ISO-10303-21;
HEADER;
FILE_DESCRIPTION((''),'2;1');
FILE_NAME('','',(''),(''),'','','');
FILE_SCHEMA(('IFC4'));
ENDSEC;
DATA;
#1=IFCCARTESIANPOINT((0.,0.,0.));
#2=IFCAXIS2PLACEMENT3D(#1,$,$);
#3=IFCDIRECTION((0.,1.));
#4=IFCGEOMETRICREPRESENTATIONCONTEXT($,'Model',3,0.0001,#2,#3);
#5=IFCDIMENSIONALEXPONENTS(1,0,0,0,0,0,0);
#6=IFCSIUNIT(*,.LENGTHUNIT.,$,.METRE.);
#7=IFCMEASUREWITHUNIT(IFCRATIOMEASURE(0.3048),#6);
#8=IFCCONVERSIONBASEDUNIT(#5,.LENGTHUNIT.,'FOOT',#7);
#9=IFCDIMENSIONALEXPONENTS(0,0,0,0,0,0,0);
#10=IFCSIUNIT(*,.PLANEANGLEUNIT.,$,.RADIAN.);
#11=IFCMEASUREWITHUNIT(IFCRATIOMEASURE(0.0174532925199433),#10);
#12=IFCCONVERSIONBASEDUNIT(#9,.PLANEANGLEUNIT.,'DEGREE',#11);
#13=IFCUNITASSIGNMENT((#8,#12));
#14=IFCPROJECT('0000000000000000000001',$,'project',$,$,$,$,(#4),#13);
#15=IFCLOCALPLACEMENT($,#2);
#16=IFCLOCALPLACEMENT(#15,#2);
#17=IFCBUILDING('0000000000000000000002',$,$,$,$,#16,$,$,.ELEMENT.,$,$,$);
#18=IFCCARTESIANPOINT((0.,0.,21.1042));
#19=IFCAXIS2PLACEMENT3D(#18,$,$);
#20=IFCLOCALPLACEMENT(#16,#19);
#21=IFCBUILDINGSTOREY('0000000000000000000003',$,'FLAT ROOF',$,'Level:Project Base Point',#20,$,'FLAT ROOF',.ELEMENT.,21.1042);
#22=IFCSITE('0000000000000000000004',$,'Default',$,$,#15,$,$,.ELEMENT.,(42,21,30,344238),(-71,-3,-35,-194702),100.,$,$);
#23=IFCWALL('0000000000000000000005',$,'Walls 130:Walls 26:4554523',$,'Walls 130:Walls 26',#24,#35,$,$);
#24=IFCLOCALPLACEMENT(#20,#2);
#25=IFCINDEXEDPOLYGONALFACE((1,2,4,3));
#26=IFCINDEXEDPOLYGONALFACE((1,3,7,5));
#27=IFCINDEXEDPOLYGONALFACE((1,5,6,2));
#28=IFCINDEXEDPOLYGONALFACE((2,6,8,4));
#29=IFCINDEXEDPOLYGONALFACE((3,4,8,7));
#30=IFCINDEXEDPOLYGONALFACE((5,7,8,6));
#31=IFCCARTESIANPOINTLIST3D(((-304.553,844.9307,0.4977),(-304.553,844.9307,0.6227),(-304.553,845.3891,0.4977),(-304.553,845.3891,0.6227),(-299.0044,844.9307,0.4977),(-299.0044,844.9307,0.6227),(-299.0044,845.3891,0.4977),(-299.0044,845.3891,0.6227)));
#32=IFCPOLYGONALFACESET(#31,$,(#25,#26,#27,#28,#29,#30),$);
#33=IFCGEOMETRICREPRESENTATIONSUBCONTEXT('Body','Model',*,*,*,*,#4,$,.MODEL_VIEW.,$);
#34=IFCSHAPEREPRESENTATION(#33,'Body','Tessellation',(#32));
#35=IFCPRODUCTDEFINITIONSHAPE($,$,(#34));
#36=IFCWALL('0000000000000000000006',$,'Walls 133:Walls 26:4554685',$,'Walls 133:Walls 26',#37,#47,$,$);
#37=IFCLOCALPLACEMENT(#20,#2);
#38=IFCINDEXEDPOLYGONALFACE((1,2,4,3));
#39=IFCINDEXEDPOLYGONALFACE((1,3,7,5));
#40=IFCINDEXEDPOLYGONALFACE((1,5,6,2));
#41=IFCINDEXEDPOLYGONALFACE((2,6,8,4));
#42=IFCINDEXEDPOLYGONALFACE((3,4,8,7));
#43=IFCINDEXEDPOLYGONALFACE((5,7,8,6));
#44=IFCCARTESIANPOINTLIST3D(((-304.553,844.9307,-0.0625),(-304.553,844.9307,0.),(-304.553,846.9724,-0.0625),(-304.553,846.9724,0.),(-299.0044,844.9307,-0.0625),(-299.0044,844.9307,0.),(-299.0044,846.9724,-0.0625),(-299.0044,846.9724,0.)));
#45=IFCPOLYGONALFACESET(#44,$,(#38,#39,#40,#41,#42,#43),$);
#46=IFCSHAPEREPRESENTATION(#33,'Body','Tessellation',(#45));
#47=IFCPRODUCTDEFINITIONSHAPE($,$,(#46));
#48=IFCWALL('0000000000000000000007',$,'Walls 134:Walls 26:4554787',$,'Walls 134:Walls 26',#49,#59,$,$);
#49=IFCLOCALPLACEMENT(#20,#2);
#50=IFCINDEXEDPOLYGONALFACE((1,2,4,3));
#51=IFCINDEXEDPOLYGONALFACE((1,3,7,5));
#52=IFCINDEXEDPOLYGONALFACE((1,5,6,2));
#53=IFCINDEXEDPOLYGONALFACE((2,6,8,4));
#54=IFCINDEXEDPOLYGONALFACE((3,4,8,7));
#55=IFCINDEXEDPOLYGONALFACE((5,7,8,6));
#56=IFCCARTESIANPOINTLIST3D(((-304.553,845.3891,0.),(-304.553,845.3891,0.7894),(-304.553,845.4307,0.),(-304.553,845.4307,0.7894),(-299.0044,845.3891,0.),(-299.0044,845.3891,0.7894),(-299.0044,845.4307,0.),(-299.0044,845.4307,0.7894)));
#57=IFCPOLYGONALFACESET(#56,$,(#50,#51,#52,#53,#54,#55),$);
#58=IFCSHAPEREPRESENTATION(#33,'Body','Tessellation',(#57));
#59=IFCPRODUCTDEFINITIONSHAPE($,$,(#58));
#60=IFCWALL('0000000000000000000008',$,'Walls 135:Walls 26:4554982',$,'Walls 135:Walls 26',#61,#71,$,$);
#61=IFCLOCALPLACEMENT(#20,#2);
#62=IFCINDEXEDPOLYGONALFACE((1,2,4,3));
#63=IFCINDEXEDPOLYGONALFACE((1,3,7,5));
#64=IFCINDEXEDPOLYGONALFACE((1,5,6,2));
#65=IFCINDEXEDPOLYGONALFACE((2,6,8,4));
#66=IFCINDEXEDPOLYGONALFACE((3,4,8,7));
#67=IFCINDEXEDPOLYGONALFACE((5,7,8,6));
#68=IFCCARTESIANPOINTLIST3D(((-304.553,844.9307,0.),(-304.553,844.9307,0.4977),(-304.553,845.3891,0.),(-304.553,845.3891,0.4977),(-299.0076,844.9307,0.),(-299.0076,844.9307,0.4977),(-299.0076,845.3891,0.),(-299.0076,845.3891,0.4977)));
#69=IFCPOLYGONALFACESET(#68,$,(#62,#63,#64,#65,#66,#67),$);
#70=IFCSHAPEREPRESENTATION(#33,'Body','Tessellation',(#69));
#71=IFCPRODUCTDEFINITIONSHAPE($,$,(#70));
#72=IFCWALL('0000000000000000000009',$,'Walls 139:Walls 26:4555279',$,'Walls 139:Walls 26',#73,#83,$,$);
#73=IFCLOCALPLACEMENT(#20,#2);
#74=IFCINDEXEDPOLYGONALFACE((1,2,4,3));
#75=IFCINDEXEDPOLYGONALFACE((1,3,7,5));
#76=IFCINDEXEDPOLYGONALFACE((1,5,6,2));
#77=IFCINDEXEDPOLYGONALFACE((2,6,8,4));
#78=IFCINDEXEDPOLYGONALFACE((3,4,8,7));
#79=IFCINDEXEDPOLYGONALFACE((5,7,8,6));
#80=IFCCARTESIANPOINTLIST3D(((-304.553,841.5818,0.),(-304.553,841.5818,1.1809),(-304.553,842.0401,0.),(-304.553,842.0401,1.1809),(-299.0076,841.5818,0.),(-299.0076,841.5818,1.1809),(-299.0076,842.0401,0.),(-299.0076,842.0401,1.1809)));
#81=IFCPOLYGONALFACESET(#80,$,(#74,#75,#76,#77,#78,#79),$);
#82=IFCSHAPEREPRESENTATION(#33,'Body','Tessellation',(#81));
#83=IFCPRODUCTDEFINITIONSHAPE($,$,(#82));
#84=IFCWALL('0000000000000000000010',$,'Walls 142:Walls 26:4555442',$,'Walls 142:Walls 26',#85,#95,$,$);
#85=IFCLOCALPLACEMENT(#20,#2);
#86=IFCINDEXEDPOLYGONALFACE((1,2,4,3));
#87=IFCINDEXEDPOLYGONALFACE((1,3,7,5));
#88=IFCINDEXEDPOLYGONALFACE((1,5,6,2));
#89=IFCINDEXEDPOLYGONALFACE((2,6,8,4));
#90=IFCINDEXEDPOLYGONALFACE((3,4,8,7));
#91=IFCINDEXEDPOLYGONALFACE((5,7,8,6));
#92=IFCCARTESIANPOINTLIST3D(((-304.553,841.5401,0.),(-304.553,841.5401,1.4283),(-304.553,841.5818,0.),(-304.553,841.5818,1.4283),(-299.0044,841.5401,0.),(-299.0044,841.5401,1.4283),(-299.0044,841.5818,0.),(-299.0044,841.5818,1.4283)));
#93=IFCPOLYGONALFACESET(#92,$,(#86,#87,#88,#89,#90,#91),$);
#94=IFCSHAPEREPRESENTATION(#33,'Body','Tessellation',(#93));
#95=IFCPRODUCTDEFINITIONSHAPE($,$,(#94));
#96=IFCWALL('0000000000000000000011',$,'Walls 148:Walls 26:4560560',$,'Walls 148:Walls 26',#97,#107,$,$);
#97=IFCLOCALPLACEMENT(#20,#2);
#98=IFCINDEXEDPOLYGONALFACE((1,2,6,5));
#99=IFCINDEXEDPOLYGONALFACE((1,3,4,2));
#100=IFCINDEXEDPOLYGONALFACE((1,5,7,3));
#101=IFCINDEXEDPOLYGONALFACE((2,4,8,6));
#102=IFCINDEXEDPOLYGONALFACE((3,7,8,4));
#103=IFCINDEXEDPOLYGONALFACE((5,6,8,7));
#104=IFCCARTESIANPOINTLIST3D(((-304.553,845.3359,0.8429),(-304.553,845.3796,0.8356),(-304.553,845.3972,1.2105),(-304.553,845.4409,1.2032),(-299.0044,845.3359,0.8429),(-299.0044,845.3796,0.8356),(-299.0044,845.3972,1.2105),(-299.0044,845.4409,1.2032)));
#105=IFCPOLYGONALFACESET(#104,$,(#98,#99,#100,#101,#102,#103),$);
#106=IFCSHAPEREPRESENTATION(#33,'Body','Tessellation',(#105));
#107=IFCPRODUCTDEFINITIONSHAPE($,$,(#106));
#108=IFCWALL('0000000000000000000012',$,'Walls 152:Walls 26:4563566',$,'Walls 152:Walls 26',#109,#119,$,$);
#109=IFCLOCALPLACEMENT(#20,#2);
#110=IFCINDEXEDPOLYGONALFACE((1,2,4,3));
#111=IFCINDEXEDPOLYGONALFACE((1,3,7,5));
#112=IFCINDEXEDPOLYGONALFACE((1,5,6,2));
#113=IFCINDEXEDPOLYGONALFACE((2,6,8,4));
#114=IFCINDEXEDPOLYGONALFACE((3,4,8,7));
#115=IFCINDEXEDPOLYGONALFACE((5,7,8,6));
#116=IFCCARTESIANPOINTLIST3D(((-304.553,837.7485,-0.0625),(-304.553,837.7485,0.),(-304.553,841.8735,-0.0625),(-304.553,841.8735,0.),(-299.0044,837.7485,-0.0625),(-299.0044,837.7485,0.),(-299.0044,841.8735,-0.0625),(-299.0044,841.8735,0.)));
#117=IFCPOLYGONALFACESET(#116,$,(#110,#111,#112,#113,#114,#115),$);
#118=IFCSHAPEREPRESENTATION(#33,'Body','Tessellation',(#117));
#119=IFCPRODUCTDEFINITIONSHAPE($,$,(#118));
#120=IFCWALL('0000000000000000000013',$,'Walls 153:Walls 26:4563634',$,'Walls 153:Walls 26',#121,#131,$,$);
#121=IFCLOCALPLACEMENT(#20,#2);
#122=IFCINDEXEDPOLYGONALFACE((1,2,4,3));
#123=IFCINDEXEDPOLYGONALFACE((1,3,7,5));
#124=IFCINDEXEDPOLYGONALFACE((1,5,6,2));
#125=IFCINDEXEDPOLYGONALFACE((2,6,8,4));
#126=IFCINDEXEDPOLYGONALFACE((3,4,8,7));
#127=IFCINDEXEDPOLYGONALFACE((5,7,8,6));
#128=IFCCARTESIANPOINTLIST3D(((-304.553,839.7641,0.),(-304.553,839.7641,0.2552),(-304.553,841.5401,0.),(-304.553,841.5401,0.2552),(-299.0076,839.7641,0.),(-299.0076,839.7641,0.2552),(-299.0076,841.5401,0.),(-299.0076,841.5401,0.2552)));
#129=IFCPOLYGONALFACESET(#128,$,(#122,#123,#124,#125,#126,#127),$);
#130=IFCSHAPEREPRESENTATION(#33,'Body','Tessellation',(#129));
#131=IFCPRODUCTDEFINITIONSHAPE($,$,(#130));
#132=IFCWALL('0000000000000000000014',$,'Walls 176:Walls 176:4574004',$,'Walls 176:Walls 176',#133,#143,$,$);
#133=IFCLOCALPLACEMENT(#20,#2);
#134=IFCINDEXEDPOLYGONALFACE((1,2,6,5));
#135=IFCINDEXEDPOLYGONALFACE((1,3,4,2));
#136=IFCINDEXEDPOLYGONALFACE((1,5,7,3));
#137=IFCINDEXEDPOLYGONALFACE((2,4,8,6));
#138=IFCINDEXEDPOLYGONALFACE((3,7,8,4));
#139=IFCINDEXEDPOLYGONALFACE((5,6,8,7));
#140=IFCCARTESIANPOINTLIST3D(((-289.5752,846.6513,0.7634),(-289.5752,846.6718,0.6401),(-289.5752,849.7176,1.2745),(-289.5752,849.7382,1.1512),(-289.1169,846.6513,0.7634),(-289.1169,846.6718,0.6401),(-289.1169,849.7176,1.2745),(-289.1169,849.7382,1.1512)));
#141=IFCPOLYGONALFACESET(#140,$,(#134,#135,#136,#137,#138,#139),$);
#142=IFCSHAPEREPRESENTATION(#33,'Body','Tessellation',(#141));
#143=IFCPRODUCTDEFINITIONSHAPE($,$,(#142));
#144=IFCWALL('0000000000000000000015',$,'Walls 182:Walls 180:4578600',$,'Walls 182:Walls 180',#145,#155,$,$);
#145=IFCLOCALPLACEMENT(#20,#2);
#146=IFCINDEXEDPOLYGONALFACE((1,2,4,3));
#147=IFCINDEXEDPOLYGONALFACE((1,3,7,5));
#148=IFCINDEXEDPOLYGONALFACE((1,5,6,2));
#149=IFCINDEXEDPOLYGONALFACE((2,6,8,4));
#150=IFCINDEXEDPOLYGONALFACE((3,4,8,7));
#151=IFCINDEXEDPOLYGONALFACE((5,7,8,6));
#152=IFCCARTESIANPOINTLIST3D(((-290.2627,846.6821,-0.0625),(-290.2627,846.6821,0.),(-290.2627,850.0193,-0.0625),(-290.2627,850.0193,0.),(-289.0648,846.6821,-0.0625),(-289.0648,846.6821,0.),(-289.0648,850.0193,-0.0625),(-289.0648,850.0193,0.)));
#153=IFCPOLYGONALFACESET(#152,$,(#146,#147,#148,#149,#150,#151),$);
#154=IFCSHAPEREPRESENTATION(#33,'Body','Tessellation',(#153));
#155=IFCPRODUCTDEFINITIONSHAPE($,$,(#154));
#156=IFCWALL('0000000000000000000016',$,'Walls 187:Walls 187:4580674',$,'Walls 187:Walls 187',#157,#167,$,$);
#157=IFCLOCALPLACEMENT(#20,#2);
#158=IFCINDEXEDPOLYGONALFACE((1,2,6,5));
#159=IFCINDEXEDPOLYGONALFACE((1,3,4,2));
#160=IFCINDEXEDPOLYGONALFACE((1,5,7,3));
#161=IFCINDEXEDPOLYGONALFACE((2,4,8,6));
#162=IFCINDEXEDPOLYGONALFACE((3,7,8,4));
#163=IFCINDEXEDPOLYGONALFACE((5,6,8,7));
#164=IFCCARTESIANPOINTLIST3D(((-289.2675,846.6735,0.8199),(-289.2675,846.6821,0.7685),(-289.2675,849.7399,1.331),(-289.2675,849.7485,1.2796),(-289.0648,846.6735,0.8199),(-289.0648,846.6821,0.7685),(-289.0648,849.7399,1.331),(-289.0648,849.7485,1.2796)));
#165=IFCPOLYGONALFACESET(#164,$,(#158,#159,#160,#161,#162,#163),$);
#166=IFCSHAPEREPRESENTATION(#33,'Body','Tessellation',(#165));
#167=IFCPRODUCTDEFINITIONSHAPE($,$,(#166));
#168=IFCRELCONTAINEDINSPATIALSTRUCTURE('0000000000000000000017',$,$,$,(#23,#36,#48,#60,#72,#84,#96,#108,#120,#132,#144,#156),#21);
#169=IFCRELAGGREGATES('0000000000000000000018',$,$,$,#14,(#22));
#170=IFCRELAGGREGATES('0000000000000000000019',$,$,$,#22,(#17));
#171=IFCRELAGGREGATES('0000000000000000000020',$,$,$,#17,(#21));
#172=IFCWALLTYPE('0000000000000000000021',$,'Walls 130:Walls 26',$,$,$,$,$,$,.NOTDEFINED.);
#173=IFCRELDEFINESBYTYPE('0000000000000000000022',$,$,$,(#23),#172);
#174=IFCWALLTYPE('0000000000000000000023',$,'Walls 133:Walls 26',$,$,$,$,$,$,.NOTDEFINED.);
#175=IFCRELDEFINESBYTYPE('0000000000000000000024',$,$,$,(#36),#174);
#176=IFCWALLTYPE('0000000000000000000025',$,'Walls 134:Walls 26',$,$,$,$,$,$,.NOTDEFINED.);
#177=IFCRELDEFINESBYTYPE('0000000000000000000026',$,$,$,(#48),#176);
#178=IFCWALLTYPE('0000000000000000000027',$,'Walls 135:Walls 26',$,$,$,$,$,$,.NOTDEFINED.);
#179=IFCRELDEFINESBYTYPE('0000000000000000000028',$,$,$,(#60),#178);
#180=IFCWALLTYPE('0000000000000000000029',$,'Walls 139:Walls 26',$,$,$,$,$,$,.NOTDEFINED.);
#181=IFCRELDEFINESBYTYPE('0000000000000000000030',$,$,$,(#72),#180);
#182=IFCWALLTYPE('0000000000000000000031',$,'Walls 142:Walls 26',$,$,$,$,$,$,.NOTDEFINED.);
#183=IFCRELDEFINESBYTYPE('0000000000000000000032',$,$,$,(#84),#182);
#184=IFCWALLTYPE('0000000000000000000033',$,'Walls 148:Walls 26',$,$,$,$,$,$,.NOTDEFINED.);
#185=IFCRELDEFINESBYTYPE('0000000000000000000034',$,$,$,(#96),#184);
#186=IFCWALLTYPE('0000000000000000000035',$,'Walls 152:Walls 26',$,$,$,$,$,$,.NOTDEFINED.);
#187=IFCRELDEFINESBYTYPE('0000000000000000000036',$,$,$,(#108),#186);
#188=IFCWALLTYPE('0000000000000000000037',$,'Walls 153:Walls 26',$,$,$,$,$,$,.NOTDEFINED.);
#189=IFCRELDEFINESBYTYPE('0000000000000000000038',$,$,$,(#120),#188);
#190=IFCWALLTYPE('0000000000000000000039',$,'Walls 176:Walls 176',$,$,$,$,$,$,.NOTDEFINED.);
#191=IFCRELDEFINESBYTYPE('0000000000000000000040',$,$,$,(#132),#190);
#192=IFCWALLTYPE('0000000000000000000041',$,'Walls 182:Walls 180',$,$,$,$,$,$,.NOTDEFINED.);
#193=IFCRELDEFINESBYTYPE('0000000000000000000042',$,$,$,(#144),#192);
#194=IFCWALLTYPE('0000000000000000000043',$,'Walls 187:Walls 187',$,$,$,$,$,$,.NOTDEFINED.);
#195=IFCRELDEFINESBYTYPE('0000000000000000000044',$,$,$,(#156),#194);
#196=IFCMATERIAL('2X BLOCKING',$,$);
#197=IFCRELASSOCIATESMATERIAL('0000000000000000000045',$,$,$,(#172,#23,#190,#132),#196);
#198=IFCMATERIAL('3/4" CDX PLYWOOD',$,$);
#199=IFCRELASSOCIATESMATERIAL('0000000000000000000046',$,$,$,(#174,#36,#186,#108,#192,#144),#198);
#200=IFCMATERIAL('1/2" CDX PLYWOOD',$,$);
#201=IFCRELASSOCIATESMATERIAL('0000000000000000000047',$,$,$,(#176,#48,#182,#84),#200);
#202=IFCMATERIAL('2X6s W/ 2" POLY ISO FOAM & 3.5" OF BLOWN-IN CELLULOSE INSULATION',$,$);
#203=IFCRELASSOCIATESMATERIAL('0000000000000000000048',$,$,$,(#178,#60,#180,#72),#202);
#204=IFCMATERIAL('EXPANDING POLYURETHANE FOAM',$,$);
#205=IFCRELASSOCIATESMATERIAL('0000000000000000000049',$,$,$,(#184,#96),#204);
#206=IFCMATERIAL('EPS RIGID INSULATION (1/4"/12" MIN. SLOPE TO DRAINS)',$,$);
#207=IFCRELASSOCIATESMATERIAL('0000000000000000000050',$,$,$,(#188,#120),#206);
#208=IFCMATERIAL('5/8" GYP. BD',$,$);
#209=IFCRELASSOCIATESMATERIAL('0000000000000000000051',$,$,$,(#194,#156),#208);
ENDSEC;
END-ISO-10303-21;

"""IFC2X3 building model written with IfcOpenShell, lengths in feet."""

from ifc_helpers import new_model, entity, si_unit, converted_unit, direction, frame, frame_2d, origin, origin_2d_with_axis, place, context, subcontext, project, spatial, rectangle, extrude, material, type_object, element, save


model = new_model("IFC2X3")

# Units and contexts
model_context = context("Model", 3, precision=0.0001, world=origin(), true_north=direction((0.0, 1.0)))
body_context = subcontext(model_context, "Body", "Model", "MODEL_VIEW")
ifc_project = project(units=[converted_unit("LENGTHUNIT", "FOOT", entity("IfcRatioMeasure", 0.3048), si_unit("LENGTHUNIT", "METRE"), dimensions=[1, 0, 0, 0, 0, 0, 0]), converted_unit("PLANEANGLEUNIT", "DEGREE", entity("IfcRatioMeasure", 0.0174532925199433), si_unit("PLANEANGLEUNIT", "RADIAN"), dimensions=[0, 0, 0, 0, 0, 0, 0])], contexts=[model_context])

# Site, building, storey
site_placement = place(None, origin())
site = spatial("IfcSite", under=ifc_project, at=site_placement, Name="Default", CompositionType="ELEMENT", RefLatitude=(42, 21, 30, 344238), RefLongitude=(-71, -3, -35, -194702), RefElevation=100.0)
building_placement = place(site_placement, origin())
building = spatial("IfcBuilding", under=site, at=building_placement, CompositionType="ELEMENT")
storey_placement = place(building_placement, frame((0.0, 0.0, 21.1042)))
storey = spatial("IfcBuildingStorey", under=building, at=storey_placement, Name="FLAT ROOF", ObjectType="Level:Project Base Point", LongName="FLAT ROOF", CompositionType="ELEMENT", Elevation=21.1042)

# Walls
ifc_material_1 = material(Name="1/2\" CDX PLYWOOD")
ifc_material_2 = material(Name="3/4\" CDX PLYWOOD")
ifc_material_3 = material(Name="EPS RIGID INSULATION (1/4\"/12\" MIN. SLOPE TO DRAINS)")
ifc_material_4 = material(Name="2X BLOCKING")
wall_type_1 = type_object("IfcWallType", Name="Walls 130:Walls 26", PredefinedType="NOTDEFINED", material=ifc_material_4)
wall_1_placement = place(storey_placement, frame((-304.553, 844.9307, 0.4977)))
element("IfcWall", 1, at=wall_1_placement, inside=storey, type_object=wall_type_1, material=ifc_material_4, Name="Walls 130:Walls 26:4554523", ObjectType="Walls 130:Walls 26", context=body_context, shape_type="SweptSolid", body=[
    extrude(rectangle(XDim=5.5486, YDim=0.4583, at=origin_2d_with_axis()), frame((2.7743, 0.2292, 0.0), z_axis=(0.0, 0.0, 1.0), x_axis=(-1.0, 0.0, 0.0)), (0.0, 0.0, 1.0), 0.125),
])
wall_type_2 = type_object("IfcWallType", Name="Walls 133:Walls 26", PredefinedType="NOTDEFINED", material=ifc_material_2)
wall_2_placement = place(storey_placement, frame((-304.553, 844.9307, -0.0625)))
element("IfcWall", 2, at=wall_2_placement, inside=storey, type_object=wall_type_2, material=ifc_material_2, Name="Walls 133:Walls 26:4554685", ObjectType="Walls 133:Walls 26", context=body_context, shape_type="SweptSolid", body=[
    extrude(rectangle(XDim=5.5486, YDim=2.0417, at=frame_2d((0.0, 0.0), x_axis=(1.0, 0.0))), frame((2.7743, 1.0208, 0.0), z_axis=(0.0, 0.0, 1.0), x_axis=(-1.0, 0.0, 0.0)), (0.0, 0.0, 1.0), 0.0625),
])
wall_type_3 = type_object("IfcWallType", Name="Walls 134:Walls 26", PredefinedType="NOTDEFINED", material=ifc_material_1)
wall_3_placement = place(storey_placement, frame((-304.553, 845.3891, 0.0)))
element("IfcWall", 3, at=wall_3_placement, inside=storey, type_object=wall_type_3, material=ifc_material_1, Name="Walls 134:Walls 26:4554787", ObjectType="Walls 134:Walls 26", context=body_context, shape_type="SweptSolid", body=[
    extrude(rectangle(XDim=5.5486, YDim=0.0417, at=frame_2d((0.0, 0.0), x_axis=(1.0, 0.0))), frame((2.7743, 0.0208, 0.0), z_axis=(0.0, 0.0, 1.0), x_axis=(-1.0, 0.0, 0.0)), (0.0, 0.0, 1.0), 0.7894),
])
ifc_material_5 = material(Name="2X6s W/ 2\" POLY ISO FOAM & 3.5\" OF BLOWN-IN CELLULOSE INSULATION")
wall_type_4 = type_object("IfcWallType", Name="Walls 135:Walls 26", PredefinedType="NOTDEFINED", material=ifc_material_5)
wall_4_placement = place(storey_placement, frame((-304.553, 844.9307, 0.0)))
element("IfcWall", 4, at=wall_4_placement, inside=storey, type_object=wall_type_4, material=ifc_material_5, Name="Walls 135:Walls 26:4554982", ObjectType="Walls 135:Walls 26", context=body_context, shape_type="SweptSolid", body=[
    extrude(rectangle(XDim=5.5454, YDim=0.4583, at=origin_2d_with_axis()), frame((2.7727, 0.2292, 0.0), z_axis=(0.0, 0.0, 1.0), x_axis=(-1.0, 0.0, 0.0)), (0.0, 0.0, 1.0), 0.4977),
])
wall_type_5 = type_object("IfcWallType", Name="Walls 139:Walls 26", PredefinedType="NOTDEFINED", material=ifc_material_5)
wall_5_placement = place(storey_placement, frame((-304.553, 841.5818, 0.0)))
element("IfcWall", 5, at=wall_5_placement, inside=storey, type_object=wall_type_5, material=ifc_material_5, Name="Walls 139:Walls 26:4555279", ObjectType="Walls 139:Walls 26", context=body_context, shape_type="SweptSolid", body=[
    extrude(rectangle(XDim=5.5454, YDim=0.4583, at=origin_2d_with_axis()), frame((2.7727, 0.2292, 0.0), z_axis=(0.0, 0.0, 1.0), x_axis=(-1.0, 0.0, 0.0)), (0.0, 0.0, 1.0), 1.1809),
])
wall_type_6 = type_object("IfcWallType", Name="Walls 142:Walls 26", PredefinedType="NOTDEFINED", material=ifc_material_1)
wall_6_placement = place(storey_placement, frame((-304.553, 841.5401, 0.0)))
element("IfcWall", 6, at=wall_6_placement, inside=storey, type_object=wall_type_6, material=ifc_material_1, Name="Walls 142:Walls 26:4555442", ObjectType="Walls 142:Walls 26", context=body_context, shape_type="SweptSolid", body=[
    extrude(rectangle(XDim=5.5486, YDim=0.0417, at=frame_2d((0.0, 0.0), x_axis=(1.0, 0.0))), frame((2.7743, 0.0208, 0.0), z_axis=(0.0, 0.0, 1.0), x_axis=(-1.0, 0.0, 0.0)), (0.0, 0.0, 1.0), 1.4283),
])
ifc_material_6 = material(Name="EXPANDING POLYURETHANE FOAM")
wall_type_7 = type_object("IfcWallType", Name="Walls 148:Walls 26", PredefinedType="NOTDEFINED", material=ifc_material_6)
wall_7_placement = place(storey_placement, frame((-304.553, 845.3359, 0.8356)))
element("IfcWall", 7, at=wall_7_placement, inside=storey, type_object=wall_type_7, material=ifc_material_6, Name="Walls 148:Walls 26:4560560", ObjectType="Walls 148:Walls 26", context=body_context, shape_type="SweptSolid", body=[
    extrude(rectangle(XDim=0.0443, YDim=5.5486, at=frame_2d((0.0, 0.0), x_axis=(0.0, 1.0))), frame((2.7743, 0.0219, 0.0036), z_axis=(0.0, 0.164399, 0.986394), x_axis=(-1.0, 0.0, 0.0)), (0.0, 0.0, 1.0), 0.3726),
])
wall_type_8 = type_object("IfcWallType", Name="Walls 152:Walls 26", PredefinedType="NOTDEFINED", material=ifc_material_2)
wall_8_placement = place(storey_placement, frame((-304.553, 837.7485, -0.0625)))
element("IfcWall", 8, at=wall_8_placement, inside=storey, type_object=wall_type_8, material=ifc_material_2, Name="Walls 152:Walls 26:4563566", ObjectType="Walls 152:Walls 26", context=body_context, shape_type="SweptSolid", body=[
    extrude(rectangle(XDim=5.5486, YDim=4.125, at=origin_2d_with_axis()), frame((2.7743, 2.0625, 0.0), z_axis=(0.0, 0.0, 1.0), x_axis=(-1.0, 0.0, 0.0)), (0.0, 0.0, 1.0), 0.0625),
])
wall_type_9 = type_object("IfcWallType", Name="Walls 153:Walls 26", PredefinedType="NOTDEFINED", material=ifc_material_3)
wall_9_placement = place(storey_placement, frame((-304.553, 839.7641, 0.0)))
element("IfcWall", 9, at=wall_9_placement, inside=storey, type_object=wall_type_9, material=ifc_material_3, Name="Walls 153:Walls 26:4563634", ObjectType="Walls 153:Walls 26", context=body_context, shape_type="SweptSolid", body=[
    extrude(rectangle(XDim=5.5454, YDim=1.776, at=frame_2d((0.0, 0.0), x_axis=(1.0, 0.0))), frame((2.7727, 0.888, 0.0), z_axis=(0.0, 0.0, 1.0), x_axis=(-1.0, 0.0, 0.0)), (0.0, 0.0, 1.0), 0.2552),
])
wall_type_10 = type_object("IfcWallType", Name="Walls 176:Walls 176", PredefinedType="NOTDEFINED", material=ifc_material_4)
wall_10_placement = place(storey_placement, frame((-289.5752, 846.6513, 0.6401), z_axis=(0.0, 0.0, 1.0), x_axis=(0.0, 1.0, 0.0)))
element("IfcWall", 10, at=wall_10_placement, inside=storey, type_object=wall_type_10, material=ifc_material_4, Name="Walls 176:Walls 176:4574004", ObjectType="Walls 176:Walls 176", context=body_context, shape_type="SweptSolid", body=[
    extrude(rectangle(XDim=3.1086, YDim=0.4583, at=frame_2d((0.0, 0.0), x_axis=(1.0, 0.0))), frame((1.5537, -0.2292, 0.2555), z_axis=(-0.164399, 0.0, 0.986394), x_axis=(-0.986394, 0.0, -0.164399)), (0.0, 0.0, 1.0), 0.125),
])
wall_type_11 = type_object("IfcWallType", Name="Walls 182:Walls 180", PredefinedType="NOTDEFINED", material=ifc_material_2)
wall_11_placement = place(storey_placement, frame((-290.2627, 846.6821, -0.0625), z_axis=(0.0, 0.0, 1.0), x_axis=(0.0, 1.0, 0.0)))
element("IfcWall", 11, at=wall_11_placement, inside=storey, type_object=wall_type_11, material=ifc_material_2, Name="Walls 182:Walls 180:4578600", ObjectType="Walls 182:Walls 180", context=body_context, shape_type="SweptSolid", body=[
    extrude(rectangle(XDim=1.1979, YDim=3.3372, at=frame_2d((0.0, 0.0), x_axis=(1.0, 0.0))), frame((1.6686, -0.599, 0.0), z_axis=(0.0, 0.0, 1.0), x_axis=(0.0, -1.0, 0.0)), (0.0, 0.0, 1.0), 0.0625),
])
ifc_material_7 = material(Name="5/8\" GYP. BD")
wall_type_12 = type_object("IfcWallType", Name="Walls 187:Walls 187", PredefinedType="NOTDEFINED", material=ifc_material_7)
wall_12_placement = place(storey_placement, frame((-289.2675, 846.6735, 0.7685), z_axis=(0.0, 0.0, 1.0), x_axis=(0.0, 1.0, 0.0)))
element("IfcWall", 12, at=wall_12_placement, inside=storey, type_object=wall_type_12, material=ifc_material_7, Name="Walls 187:Walls 187:4580674", ObjectType="Walls 187:Walls 187", context=body_context, shape_type="SweptSolid", body=[
    extrude(rectangle(XDim=3.1086, YDim=0.2028, at=origin_2d_with_axis()), frame((1.5417, -0.1014, 0.2555), z_axis=(-0.164399, 0.0, 0.986394), x_axis=(-0.986394, 0.0, -0.164399)), (0.0, 0.0, 1.0), 0.0521),
])

save(model, "model.ifc")
